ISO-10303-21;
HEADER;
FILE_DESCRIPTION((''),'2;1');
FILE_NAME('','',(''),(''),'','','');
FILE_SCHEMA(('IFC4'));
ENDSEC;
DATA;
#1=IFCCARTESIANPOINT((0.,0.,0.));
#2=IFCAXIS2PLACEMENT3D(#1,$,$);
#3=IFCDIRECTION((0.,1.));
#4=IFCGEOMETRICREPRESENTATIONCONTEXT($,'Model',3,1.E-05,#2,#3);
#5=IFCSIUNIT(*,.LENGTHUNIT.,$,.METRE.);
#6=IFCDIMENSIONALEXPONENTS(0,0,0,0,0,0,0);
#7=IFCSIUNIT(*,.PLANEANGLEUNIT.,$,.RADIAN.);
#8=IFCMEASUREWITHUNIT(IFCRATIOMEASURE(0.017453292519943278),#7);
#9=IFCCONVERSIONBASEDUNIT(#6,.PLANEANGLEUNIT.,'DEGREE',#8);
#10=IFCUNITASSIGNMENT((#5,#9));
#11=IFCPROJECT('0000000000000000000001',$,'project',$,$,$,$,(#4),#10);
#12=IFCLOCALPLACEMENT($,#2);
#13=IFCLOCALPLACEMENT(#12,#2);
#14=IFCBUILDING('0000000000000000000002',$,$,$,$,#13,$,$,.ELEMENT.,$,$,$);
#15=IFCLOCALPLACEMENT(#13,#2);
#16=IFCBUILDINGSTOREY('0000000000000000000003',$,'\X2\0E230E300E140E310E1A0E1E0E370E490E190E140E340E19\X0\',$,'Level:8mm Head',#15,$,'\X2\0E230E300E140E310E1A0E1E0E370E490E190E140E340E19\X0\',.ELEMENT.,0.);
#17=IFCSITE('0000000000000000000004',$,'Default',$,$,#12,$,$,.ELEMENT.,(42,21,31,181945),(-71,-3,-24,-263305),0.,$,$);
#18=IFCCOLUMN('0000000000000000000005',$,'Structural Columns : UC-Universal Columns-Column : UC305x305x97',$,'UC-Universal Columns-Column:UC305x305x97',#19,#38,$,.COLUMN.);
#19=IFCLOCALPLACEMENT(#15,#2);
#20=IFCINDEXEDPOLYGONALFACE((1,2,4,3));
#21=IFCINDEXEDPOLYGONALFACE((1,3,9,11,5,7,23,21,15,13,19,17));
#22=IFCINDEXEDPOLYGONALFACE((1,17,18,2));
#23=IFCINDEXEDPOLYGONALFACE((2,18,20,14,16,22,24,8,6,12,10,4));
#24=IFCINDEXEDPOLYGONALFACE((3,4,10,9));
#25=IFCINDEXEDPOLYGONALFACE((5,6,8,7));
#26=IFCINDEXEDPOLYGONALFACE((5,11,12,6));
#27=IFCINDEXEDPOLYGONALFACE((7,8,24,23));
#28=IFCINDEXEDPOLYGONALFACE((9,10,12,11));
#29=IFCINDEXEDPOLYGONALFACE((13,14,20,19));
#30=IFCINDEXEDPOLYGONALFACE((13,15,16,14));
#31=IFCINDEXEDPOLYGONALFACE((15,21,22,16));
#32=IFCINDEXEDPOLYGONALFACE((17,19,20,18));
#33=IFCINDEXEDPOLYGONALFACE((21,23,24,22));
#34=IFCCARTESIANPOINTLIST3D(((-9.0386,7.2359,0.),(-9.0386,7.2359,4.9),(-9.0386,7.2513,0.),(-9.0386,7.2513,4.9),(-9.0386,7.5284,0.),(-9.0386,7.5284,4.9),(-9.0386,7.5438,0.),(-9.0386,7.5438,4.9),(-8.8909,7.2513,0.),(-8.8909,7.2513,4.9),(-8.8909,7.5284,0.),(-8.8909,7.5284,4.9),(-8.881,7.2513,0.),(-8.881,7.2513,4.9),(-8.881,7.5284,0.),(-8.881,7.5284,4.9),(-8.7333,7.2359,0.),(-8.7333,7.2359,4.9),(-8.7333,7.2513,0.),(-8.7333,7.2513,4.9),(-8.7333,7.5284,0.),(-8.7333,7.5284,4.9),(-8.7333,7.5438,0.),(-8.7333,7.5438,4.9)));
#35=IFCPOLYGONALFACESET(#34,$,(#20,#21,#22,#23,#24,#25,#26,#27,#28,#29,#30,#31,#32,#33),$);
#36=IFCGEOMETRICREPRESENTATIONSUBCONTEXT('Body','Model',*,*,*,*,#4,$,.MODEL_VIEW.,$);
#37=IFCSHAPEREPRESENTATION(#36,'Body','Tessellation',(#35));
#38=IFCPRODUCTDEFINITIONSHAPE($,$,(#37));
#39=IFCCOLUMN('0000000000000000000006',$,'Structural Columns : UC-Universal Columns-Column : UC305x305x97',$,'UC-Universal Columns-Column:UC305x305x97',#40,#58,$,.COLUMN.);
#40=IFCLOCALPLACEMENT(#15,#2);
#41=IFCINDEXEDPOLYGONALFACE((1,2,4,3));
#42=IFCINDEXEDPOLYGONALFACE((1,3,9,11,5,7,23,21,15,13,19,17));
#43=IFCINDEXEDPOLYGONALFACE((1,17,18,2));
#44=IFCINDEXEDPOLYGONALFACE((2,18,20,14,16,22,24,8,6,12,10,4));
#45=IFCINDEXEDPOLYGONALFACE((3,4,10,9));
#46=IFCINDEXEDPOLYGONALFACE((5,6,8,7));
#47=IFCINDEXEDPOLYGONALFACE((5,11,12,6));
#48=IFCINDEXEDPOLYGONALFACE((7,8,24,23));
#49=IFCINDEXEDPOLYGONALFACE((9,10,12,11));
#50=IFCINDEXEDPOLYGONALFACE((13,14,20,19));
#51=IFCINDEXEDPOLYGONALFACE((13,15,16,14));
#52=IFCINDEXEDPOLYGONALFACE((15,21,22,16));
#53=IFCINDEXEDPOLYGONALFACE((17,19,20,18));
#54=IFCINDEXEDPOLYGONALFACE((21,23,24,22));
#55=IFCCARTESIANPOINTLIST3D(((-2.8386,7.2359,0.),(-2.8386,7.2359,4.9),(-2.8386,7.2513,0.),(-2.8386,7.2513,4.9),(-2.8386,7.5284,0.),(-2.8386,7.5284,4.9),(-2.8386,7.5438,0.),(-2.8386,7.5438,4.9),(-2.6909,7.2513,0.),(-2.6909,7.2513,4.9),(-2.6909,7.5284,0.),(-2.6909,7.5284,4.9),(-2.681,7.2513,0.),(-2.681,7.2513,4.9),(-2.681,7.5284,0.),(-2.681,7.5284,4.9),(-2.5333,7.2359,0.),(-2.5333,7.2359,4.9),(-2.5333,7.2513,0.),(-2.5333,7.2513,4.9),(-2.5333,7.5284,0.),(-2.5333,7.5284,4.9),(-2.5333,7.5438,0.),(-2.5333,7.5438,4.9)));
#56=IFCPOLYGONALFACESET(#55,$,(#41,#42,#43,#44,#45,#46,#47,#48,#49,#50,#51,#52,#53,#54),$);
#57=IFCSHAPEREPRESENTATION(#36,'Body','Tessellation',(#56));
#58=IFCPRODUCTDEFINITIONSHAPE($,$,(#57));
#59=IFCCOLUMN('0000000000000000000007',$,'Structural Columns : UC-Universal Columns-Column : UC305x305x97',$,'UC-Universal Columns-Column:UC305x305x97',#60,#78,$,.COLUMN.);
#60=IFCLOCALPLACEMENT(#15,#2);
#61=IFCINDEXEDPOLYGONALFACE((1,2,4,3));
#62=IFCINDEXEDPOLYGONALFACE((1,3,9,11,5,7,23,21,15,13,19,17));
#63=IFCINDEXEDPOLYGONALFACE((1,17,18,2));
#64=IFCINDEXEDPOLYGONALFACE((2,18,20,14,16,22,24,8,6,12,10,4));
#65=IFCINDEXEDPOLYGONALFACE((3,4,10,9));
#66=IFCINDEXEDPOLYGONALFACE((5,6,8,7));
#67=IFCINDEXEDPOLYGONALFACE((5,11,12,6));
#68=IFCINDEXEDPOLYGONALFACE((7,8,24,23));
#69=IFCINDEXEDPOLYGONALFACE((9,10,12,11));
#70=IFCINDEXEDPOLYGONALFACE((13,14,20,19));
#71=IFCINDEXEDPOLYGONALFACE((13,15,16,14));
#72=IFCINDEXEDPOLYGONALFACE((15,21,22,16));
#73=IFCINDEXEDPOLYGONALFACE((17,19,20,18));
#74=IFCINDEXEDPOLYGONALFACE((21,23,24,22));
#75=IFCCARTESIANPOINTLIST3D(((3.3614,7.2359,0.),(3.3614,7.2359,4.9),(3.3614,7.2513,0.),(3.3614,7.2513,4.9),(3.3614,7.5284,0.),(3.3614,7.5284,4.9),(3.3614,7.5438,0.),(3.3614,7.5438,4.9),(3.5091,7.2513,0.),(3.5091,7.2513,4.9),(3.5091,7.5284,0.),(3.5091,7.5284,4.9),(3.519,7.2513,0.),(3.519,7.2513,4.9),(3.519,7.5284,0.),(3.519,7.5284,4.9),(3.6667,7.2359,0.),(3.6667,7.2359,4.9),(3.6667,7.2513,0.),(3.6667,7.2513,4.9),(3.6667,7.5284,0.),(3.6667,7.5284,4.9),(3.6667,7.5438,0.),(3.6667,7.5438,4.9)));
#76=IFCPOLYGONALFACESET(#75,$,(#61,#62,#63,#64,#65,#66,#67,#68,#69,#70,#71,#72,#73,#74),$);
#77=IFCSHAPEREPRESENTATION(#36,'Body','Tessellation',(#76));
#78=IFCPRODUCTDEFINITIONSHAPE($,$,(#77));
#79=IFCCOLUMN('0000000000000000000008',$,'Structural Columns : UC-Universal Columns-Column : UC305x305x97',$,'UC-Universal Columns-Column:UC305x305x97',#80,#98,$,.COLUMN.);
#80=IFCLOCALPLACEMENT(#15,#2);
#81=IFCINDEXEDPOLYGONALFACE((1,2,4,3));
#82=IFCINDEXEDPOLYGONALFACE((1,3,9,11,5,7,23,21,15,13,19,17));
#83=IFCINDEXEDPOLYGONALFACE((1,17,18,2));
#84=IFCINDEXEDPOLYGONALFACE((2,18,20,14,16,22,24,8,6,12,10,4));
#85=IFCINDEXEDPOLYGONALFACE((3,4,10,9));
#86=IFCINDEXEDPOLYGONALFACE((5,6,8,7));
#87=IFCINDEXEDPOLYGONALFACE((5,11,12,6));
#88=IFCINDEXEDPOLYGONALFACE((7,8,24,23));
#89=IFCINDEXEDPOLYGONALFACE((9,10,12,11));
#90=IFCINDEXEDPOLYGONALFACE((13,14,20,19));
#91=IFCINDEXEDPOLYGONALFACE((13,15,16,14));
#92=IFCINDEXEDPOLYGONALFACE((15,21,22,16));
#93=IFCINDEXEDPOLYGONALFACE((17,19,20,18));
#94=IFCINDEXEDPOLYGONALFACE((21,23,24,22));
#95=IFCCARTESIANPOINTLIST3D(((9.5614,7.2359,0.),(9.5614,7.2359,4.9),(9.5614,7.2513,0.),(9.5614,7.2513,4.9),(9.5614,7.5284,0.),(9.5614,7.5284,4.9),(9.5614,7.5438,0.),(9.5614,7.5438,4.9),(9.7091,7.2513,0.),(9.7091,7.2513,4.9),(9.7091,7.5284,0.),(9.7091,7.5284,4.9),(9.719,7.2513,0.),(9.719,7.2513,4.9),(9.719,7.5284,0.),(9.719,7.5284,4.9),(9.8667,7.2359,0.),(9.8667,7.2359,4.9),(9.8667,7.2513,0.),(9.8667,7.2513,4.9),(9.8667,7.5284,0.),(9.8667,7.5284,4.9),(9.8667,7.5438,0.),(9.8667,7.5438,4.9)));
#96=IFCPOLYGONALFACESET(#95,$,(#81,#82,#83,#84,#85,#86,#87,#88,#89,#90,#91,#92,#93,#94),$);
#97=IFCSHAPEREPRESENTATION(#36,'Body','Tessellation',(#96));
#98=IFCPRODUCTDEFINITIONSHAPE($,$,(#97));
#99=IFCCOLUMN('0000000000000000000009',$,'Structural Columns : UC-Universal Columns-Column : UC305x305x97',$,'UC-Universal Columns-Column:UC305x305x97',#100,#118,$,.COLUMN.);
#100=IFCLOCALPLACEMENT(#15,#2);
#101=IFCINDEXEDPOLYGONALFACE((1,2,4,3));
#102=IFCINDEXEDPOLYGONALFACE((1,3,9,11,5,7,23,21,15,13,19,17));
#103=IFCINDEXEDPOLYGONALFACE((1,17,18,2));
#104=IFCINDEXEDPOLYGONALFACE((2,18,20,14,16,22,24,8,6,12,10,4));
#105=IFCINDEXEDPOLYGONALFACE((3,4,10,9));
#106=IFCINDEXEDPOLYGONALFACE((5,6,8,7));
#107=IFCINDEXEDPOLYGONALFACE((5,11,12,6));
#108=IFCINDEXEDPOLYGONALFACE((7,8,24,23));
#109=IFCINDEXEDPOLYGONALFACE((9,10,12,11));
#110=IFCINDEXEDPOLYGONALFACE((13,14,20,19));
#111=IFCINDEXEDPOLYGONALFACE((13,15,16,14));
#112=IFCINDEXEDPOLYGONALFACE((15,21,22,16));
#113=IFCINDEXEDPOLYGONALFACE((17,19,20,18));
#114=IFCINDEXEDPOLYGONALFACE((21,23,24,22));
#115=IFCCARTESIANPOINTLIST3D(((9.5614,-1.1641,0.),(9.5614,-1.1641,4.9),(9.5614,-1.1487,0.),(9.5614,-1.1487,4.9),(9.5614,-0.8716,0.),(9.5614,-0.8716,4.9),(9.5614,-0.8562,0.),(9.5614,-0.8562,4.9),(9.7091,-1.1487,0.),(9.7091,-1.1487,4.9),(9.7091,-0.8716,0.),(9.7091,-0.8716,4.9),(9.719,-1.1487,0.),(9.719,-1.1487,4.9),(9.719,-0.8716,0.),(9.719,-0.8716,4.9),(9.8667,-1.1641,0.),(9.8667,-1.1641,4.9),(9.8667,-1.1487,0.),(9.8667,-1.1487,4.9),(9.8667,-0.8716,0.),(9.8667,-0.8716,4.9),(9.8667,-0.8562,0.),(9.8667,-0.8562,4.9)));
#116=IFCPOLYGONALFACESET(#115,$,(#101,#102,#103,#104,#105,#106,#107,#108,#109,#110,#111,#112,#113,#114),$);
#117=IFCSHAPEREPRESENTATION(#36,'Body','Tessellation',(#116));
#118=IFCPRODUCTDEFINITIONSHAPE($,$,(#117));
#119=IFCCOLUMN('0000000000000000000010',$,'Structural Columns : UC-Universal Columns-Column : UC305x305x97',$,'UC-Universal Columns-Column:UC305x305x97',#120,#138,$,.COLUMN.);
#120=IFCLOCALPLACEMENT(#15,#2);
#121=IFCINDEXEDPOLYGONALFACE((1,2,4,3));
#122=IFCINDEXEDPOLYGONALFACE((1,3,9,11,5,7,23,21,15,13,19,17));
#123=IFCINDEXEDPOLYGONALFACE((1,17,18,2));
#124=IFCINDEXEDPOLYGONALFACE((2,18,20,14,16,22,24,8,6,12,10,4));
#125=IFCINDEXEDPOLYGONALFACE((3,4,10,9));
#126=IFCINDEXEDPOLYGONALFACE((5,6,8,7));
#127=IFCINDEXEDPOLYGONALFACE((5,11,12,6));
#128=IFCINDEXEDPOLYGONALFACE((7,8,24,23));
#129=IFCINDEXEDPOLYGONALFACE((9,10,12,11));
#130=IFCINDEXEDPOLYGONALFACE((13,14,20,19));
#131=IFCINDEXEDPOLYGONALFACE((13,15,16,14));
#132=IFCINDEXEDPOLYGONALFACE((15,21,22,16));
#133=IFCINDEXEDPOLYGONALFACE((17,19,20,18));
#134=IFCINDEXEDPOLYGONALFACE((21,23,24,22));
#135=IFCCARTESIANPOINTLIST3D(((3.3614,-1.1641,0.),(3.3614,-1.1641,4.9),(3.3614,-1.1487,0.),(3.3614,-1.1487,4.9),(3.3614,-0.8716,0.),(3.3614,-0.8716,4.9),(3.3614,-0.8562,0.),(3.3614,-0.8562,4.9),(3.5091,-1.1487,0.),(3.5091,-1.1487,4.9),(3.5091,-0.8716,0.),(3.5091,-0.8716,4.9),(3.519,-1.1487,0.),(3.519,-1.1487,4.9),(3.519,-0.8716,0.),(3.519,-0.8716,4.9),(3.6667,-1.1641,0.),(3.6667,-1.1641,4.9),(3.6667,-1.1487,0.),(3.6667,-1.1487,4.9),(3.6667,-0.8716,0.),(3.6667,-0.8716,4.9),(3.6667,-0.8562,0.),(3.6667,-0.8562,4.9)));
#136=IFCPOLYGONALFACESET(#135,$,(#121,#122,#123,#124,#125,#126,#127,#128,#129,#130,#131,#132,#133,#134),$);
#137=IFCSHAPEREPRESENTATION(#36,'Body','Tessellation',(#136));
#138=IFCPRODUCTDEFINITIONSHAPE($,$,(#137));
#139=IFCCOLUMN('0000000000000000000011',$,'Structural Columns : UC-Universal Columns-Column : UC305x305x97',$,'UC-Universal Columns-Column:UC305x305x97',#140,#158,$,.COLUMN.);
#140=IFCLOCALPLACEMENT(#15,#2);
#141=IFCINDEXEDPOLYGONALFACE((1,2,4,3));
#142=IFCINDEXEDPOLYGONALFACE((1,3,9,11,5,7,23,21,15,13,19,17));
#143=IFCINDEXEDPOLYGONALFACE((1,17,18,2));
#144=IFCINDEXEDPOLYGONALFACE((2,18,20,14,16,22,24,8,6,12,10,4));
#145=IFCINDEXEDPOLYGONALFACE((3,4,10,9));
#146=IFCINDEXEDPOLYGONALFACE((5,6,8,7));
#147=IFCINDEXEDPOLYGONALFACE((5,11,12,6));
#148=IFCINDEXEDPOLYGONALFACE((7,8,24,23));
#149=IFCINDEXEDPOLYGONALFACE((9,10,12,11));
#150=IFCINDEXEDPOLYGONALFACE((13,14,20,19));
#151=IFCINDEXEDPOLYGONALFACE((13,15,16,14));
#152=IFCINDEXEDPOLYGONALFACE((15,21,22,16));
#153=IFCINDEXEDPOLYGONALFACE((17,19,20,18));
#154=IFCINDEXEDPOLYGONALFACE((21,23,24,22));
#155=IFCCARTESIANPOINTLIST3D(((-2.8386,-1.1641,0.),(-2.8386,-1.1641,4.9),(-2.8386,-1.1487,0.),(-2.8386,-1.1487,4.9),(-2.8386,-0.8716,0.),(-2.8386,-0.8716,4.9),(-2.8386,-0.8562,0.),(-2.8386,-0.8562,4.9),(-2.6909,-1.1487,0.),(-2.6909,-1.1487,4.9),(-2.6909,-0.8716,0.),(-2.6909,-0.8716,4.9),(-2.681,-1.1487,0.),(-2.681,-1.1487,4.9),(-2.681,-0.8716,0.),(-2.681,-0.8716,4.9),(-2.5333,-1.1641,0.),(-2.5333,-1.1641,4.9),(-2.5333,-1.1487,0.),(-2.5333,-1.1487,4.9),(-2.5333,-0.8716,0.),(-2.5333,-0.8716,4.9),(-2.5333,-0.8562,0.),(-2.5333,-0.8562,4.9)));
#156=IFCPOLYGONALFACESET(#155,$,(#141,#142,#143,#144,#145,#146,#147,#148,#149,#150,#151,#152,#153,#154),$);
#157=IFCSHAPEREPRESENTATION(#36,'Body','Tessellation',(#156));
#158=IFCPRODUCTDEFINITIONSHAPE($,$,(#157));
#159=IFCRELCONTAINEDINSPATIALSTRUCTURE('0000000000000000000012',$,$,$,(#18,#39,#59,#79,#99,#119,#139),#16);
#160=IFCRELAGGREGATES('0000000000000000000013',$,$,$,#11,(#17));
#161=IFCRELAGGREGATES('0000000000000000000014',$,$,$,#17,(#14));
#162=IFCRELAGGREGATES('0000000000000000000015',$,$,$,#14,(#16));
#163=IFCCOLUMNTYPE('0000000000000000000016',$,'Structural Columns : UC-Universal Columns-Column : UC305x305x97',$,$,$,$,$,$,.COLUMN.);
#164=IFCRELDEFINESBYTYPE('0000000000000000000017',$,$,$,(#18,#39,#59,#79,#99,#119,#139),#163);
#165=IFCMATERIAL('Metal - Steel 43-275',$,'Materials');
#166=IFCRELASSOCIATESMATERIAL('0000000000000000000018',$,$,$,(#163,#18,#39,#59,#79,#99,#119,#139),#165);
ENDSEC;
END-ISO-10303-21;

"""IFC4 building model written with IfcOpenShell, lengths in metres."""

from ifc_helpers import new_model, entity, si_unit, converted_unit, direction, frame, frame_2d, origin, place, context, subcontext, project, spatial, polyline, circle_curve, parameter, trimmed, segment, composite_curve, i_section, outline, extrude, source, transform, mapped, material, material_profile, profile_set, profile_usage, type_object, type_shapes, element, save


model = new_model("IFC4")

# Units and contexts
model_context = context("Model", 3, precision=1e-05, world=origin(), true_north=direction((0.0, 1.0)))
body_context = subcontext(model_context, "Body", "Model", "MODEL_VIEW")
ifc_project = project(units=[si_unit("LENGTHUNIT", "METRE"), converted_unit("PLANEANGLEUNIT", "DEGREE", entity("IfcRatioMeasure", 0.017453292519943278), si_unit("PLANEANGLEUNIT", "RADIAN"), dimensions=[0, 0, 0, 0, 0, 0, 0])], contexts=[model_context])

# Site, building, storey
site_placement = place(None, origin())
site = spatial("IfcSite", under=ifc_project, at=site_placement, Name="Default", CompositionType="ELEMENT", RefLatitude=(42, 21, 31, 181945), RefLongitude=(-71, -3, -24, -263305), RefElevation=0.0)
building_placement = place(site_placement, origin())
building = spatial("IfcBuilding", under=site, at=building_placement, CompositionType="ELEMENT")
storey_placement = place(building_placement, origin())
storey = spatial("IfcBuildingStorey", under=building, at=storey_placement, Name="ระดับพื้นดิน", ObjectType="Level:8mm Head", LongName="ระดับพื้นดิน", CompositionType="ELEMENT", Elevation=0.0)

# Columns
ifc_material_1 = material(Name="Metal - Steel 43-275", Category="Materials")
ifc_material_profile_1 = material_profile(ifc_material_1, outline(composite_curve([segment(polyline([(-0.1527, 0.154, 0.0), (0.1526, 0.154, 0.0)]), True, "CONTINUOUS"), segment(polyline([(0.1526, 0.154, 0.0), (0.1526, 0.1386, 0.0)]), True, "CONTINUOUS"), segment(polyline([(0.1526, 0.1386, 0.0), (0.0201, 0.1386, 0.0)]), True, "CONTINUOUS"), segment(trimmed(circle_curve(frame((0.0201, 0.1234, 0.0)), 0.0152), [parameter(90.0)], [parameter(180.0)], True, "PARAMETER"), True, "CONTINUOUS"), segment(polyline([(0.0049, 0.1233, 0.0), (0.0049, -0.1234, 0.0)]), True, "CONTINUOUS"), segment(trimmed(circle_curve(frame((0.0201, -0.1233, 0.0)), 0.0152), [parameter(180.0)], [parameter(270.0)], True, "PARAMETER"), True, "CONTINUOUS"), segment(polyline([(0.0201, -0.1385, 0.0), (0.1526, -0.1385, 0.0)]), True, "CONTINUOUS"), segment(polyline([(0.1526, -0.1385, 0.0), (0.1526, -0.1539, 0.0)]), True, "CONTINUOUS"), segment(polyline([(0.1526, -0.1539, 0.0), (-0.1527, -0.1539, 0.0)]), True, "CONTINUOUS"), segment(polyline([(-0.1527, -0.1539, 0.0), (-0.1527, -0.1385, 0.0)]), True, "CONTINUOUS"), segment(polyline([(-0.1527, -0.1385, 0.0), (-0.0202, -0.1385, 0.0)]), True, "CONTINUOUS"), segment(trimmed(circle_curve(frame((-0.0202, -0.1233, 0.0)), 0.0152), [parameter(270.0)], [parameter(0.0)], True, "PARAMETER"), True, "CONTINUOUS"), segment(polyline([(-0.005, -0.1233, 0.0), (-0.005, 0.1234, 0.0)]), True, "CONTINUOUS"), segment(trimmed(circle_curve(frame((-0.0202, 0.1234, 0.0)), 0.0152), [parameter(0.0)], [parameter(90.0)], True, "PARAMETER"), True, "CONTINUOUS"), segment(polyline([(-0.0202, 0.1386, 0.0), (-0.1527, 0.1386, 0.0)]), True, "CONTINUOUS"), segment(polyline([(-0.1527, 0.1386, 0.0), (-0.1527, 0.154, 0.0)]), True, "CONTINUOUS")], self_intersect=False), kind="CURVE"), Name="UC305x305x97")
ifc_material_profile_2 = material_profile(ifc_material_1, outline(composite_curve([segment(polyline([(0.1526, 0.154, 4.9), (-0.1527, 0.154, 4.9)]), True, "CONTINUOUS"), segment(polyline([(-0.1527, 0.154, 4.9), (-0.1527, 0.1386, 4.9)]), True, "CONTINUOUS"), segment(polyline([(-0.1527, 0.1386, 4.9), (-0.005, 0.1386, 4.9)]), True, "CONTINUOUS"), segment(polyline([(-0.005, 0.1386, 4.9), (-0.005, -0.1385, 4.9)]), True, "CONTINUOUS"), segment(polyline([(-0.005, -0.1385, 4.9), (-0.1527, -0.1385, 4.9)]), True, "CONTINUOUS"), segment(polyline([(-0.1527, -0.1385, 4.9), (-0.1527, -0.1539, 4.9)]), True, "CONTINUOUS"), segment(polyline([(-0.1527, -0.1539, 4.9), (0.1526, -0.1539, 4.9)]), True, "CONTINUOUS"), segment(polyline([(0.1526, -0.1539, 4.9), (0.1526, -0.1385, 4.9)]), True, "CONTINUOUS"), segment(polyline([(0.1526, -0.1385, 4.9), (0.0049, -0.1385, 4.9)]), True, "CONTINUOUS"), segment(polyline([(0.0049, -0.1385, 4.9), (0.0049, 0.1386, 4.9)]), True, "CONTINUOUS"), segment(polyline([(0.0049, 0.1386, 4.9), (0.1526, 0.1386, 4.9)]), True, "CONTINUOUS"), segment(polyline([(0.1526, 0.1386, 4.9), (0.1526, 0.154, 4.9)]), True, "CONTINUOUS")], self_intersect=False), kind="CURVE"), Name="UC305x305x97")
ifc_profile_set = profile_set([ifc_material_profile_1, ifc_material_profile_2], Name="UC305x305x97")
ifc_profile_usage_1 = profile_usage(ifc_profile_set)
column_type_1 = type_object("IfcColumnType", Name="Structural Columns : UC-Universal Columns-Column : UC305x305x97", PredefinedType="COLUMN", material=ifc_profile_set)
shared_shape_1 = source(origin(), body_context, "Body", "SweptSolid", [
    extrude(i_section(OverallWidth=0.3053, OverallDepth=0.3079, WebThickness=0.0099, FlangeThickness=0.0154, at=frame_2d((0.0, 0.0), x_axis=(0.0, 1.0))), frame((0.0, 0.0, 0.0), z_axis=(0.0, 0.0, 1.0), x_axis=(0.0, -1.0, 0.0)), (0.0, 0.0, 1.0), 4.9),
])
type_shapes(column_type_1, [shared_shape_1])
column_1_placement = place(storey_placement, frame((-8.8859, 7.3898, 0.0)))
element("IfcColumn", 1, at=column_1_placement, inside=storey, type_object=column_type_1, material=ifc_profile_usage_1, Name="Structural Columns : UC-Universal Columns-Column : UC305x305x97", ObjectType="UC-Universal Columns-Column:UC305x305x97", PredefinedType="COLUMN", context=body_context, shape_type="MappedRepresentation", body=[
    mapped(shared_shape_1, transform((0.0, 0.0, 0.0), scale=1.0)),
])
ifc_profile_usage_2 = profile_usage(ifc_profile_set)
column_2_placement = place(storey_placement, frame((-2.6859, 7.3898, 0.0)))
element("IfcColumn", 2, at=column_2_placement, inside=storey, type_object=column_type_1, material=ifc_profile_usage_2, Name="Structural Columns : UC-Universal Columns-Column : UC305x305x97", ObjectType="UC-Universal Columns-Column:UC305x305x97", PredefinedType="COLUMN", context=body_context, shape_type="MappedRepresentation", body=[
    mapped(shared_shape_1, transform((0.0, 0.0, 0.0), scale=1.0)),
])
ifc_profile_usage_3 = profile_usage(ifc_profile_set)
column_3_placement = place(storey_placement, frame((3.5141, 7.3898, 0.0)))
element("IfcColumn", 3, at=column_3_placement, inside=storey, type_object=column_type_1, material=ifc_profile_usage_3, Name="Structural Columns : UC-Universal Columns-Column : UC305x305x97", ObjectType="UC-Universal Columns-Column:UC305x305x97", PredefinedType="COLUMN", context=body_context, shape_type="MappedRepresentation", body=[
    mapped(shared_shape_1, transform((0.0, 0.0, 0.0), scale=1.0)),
])
ifc_profile_usage_4 = profile_usage(ifc_profile_set)
column_4_placement = place(storey_placement, frame((9.7141, 7.3898, 0.0)))
element("IfcColumn", 4, at=column_4_placement, inside=storey, type_object=column_type_1, material=ifc_profile_usage_4, Name="Structural Columns : UC-Universal Columns-Column : UC305x305x97", ObjectType="UC-Universal Columns-Column:UC305x305x97", PredefinedType="COLUMN", context=body_context, shape_type="MappedRepresentation", body=[
    mapped(shared_shape_1, transform((0.0, 0.0, 0.0), scale=1.0)),
])
ifc_profile_usage_5 = profile_usage(ifc_profile_set)
column_5_placement = place(storey_placement, frame((9.7141, -1.0102, 0.0)))
element("IfcColumn", 5, at=column_5_placement, inside=storey, type_object=column_type_1, material=ifc_profile_usage_5, Name="Structural Columns : UC-Universal Columns-Column : UC305x305x97", ObjectType="UC-Universal Columns-Column:UC305x305x97", PredefinedType="COLUMN", context=body_context, shape_type="MappedRepresentation", body=[
    mapped(shared_shape_1, transform((0.0, 0.0, 0.0), scale=1.0)),
])
ifc_profile_usage_6 = profile_usage(ifc_profile_set)
column_6_placement = place(storey_placement, frame((3.5141, -1.0102, 0.0)))
element("IfcColumn", 6, at=column_6_placement, inside=storey, type_object=column_type_1, material=ifc_profile_usage_6, Name="Structural Columns : UC-Universal Columns-Column : UC305x305x97", ObjectType="UC-Universal Columns-Column:UC305x305x97", PredefinedType="COLUMN", context=body_context, shape_type="MappedRepresentation", body=[
    mapped(shared_shape_1, transform((0.0, 0.0, 0.0), scale=1.0)),
])
ifc_profile_usage_7 = profile_usage(ifc_profile_set)
column_7_placement = place(storey_placement, frame((-2.6859, -1.0102, 0.0)))
element("IfcColumn", 7, at=column_7_placement, inside=storey, type_object=column_type_1, material=ifc_profile_usage_7, Name="Structural Columns : UC-Universal Columns-Column : UC305x305x97", ObjectType="UC-Universal Columns-Column:UC305x305x97", PredefinedType="COLUMN", context=body_context, shape_type="MappedRepresentation", body=[
    mapped(shared_shape_1, transform((0.0, 0.0, 0.0), scale=1.0)),
])

save(model, "model.ifc")
